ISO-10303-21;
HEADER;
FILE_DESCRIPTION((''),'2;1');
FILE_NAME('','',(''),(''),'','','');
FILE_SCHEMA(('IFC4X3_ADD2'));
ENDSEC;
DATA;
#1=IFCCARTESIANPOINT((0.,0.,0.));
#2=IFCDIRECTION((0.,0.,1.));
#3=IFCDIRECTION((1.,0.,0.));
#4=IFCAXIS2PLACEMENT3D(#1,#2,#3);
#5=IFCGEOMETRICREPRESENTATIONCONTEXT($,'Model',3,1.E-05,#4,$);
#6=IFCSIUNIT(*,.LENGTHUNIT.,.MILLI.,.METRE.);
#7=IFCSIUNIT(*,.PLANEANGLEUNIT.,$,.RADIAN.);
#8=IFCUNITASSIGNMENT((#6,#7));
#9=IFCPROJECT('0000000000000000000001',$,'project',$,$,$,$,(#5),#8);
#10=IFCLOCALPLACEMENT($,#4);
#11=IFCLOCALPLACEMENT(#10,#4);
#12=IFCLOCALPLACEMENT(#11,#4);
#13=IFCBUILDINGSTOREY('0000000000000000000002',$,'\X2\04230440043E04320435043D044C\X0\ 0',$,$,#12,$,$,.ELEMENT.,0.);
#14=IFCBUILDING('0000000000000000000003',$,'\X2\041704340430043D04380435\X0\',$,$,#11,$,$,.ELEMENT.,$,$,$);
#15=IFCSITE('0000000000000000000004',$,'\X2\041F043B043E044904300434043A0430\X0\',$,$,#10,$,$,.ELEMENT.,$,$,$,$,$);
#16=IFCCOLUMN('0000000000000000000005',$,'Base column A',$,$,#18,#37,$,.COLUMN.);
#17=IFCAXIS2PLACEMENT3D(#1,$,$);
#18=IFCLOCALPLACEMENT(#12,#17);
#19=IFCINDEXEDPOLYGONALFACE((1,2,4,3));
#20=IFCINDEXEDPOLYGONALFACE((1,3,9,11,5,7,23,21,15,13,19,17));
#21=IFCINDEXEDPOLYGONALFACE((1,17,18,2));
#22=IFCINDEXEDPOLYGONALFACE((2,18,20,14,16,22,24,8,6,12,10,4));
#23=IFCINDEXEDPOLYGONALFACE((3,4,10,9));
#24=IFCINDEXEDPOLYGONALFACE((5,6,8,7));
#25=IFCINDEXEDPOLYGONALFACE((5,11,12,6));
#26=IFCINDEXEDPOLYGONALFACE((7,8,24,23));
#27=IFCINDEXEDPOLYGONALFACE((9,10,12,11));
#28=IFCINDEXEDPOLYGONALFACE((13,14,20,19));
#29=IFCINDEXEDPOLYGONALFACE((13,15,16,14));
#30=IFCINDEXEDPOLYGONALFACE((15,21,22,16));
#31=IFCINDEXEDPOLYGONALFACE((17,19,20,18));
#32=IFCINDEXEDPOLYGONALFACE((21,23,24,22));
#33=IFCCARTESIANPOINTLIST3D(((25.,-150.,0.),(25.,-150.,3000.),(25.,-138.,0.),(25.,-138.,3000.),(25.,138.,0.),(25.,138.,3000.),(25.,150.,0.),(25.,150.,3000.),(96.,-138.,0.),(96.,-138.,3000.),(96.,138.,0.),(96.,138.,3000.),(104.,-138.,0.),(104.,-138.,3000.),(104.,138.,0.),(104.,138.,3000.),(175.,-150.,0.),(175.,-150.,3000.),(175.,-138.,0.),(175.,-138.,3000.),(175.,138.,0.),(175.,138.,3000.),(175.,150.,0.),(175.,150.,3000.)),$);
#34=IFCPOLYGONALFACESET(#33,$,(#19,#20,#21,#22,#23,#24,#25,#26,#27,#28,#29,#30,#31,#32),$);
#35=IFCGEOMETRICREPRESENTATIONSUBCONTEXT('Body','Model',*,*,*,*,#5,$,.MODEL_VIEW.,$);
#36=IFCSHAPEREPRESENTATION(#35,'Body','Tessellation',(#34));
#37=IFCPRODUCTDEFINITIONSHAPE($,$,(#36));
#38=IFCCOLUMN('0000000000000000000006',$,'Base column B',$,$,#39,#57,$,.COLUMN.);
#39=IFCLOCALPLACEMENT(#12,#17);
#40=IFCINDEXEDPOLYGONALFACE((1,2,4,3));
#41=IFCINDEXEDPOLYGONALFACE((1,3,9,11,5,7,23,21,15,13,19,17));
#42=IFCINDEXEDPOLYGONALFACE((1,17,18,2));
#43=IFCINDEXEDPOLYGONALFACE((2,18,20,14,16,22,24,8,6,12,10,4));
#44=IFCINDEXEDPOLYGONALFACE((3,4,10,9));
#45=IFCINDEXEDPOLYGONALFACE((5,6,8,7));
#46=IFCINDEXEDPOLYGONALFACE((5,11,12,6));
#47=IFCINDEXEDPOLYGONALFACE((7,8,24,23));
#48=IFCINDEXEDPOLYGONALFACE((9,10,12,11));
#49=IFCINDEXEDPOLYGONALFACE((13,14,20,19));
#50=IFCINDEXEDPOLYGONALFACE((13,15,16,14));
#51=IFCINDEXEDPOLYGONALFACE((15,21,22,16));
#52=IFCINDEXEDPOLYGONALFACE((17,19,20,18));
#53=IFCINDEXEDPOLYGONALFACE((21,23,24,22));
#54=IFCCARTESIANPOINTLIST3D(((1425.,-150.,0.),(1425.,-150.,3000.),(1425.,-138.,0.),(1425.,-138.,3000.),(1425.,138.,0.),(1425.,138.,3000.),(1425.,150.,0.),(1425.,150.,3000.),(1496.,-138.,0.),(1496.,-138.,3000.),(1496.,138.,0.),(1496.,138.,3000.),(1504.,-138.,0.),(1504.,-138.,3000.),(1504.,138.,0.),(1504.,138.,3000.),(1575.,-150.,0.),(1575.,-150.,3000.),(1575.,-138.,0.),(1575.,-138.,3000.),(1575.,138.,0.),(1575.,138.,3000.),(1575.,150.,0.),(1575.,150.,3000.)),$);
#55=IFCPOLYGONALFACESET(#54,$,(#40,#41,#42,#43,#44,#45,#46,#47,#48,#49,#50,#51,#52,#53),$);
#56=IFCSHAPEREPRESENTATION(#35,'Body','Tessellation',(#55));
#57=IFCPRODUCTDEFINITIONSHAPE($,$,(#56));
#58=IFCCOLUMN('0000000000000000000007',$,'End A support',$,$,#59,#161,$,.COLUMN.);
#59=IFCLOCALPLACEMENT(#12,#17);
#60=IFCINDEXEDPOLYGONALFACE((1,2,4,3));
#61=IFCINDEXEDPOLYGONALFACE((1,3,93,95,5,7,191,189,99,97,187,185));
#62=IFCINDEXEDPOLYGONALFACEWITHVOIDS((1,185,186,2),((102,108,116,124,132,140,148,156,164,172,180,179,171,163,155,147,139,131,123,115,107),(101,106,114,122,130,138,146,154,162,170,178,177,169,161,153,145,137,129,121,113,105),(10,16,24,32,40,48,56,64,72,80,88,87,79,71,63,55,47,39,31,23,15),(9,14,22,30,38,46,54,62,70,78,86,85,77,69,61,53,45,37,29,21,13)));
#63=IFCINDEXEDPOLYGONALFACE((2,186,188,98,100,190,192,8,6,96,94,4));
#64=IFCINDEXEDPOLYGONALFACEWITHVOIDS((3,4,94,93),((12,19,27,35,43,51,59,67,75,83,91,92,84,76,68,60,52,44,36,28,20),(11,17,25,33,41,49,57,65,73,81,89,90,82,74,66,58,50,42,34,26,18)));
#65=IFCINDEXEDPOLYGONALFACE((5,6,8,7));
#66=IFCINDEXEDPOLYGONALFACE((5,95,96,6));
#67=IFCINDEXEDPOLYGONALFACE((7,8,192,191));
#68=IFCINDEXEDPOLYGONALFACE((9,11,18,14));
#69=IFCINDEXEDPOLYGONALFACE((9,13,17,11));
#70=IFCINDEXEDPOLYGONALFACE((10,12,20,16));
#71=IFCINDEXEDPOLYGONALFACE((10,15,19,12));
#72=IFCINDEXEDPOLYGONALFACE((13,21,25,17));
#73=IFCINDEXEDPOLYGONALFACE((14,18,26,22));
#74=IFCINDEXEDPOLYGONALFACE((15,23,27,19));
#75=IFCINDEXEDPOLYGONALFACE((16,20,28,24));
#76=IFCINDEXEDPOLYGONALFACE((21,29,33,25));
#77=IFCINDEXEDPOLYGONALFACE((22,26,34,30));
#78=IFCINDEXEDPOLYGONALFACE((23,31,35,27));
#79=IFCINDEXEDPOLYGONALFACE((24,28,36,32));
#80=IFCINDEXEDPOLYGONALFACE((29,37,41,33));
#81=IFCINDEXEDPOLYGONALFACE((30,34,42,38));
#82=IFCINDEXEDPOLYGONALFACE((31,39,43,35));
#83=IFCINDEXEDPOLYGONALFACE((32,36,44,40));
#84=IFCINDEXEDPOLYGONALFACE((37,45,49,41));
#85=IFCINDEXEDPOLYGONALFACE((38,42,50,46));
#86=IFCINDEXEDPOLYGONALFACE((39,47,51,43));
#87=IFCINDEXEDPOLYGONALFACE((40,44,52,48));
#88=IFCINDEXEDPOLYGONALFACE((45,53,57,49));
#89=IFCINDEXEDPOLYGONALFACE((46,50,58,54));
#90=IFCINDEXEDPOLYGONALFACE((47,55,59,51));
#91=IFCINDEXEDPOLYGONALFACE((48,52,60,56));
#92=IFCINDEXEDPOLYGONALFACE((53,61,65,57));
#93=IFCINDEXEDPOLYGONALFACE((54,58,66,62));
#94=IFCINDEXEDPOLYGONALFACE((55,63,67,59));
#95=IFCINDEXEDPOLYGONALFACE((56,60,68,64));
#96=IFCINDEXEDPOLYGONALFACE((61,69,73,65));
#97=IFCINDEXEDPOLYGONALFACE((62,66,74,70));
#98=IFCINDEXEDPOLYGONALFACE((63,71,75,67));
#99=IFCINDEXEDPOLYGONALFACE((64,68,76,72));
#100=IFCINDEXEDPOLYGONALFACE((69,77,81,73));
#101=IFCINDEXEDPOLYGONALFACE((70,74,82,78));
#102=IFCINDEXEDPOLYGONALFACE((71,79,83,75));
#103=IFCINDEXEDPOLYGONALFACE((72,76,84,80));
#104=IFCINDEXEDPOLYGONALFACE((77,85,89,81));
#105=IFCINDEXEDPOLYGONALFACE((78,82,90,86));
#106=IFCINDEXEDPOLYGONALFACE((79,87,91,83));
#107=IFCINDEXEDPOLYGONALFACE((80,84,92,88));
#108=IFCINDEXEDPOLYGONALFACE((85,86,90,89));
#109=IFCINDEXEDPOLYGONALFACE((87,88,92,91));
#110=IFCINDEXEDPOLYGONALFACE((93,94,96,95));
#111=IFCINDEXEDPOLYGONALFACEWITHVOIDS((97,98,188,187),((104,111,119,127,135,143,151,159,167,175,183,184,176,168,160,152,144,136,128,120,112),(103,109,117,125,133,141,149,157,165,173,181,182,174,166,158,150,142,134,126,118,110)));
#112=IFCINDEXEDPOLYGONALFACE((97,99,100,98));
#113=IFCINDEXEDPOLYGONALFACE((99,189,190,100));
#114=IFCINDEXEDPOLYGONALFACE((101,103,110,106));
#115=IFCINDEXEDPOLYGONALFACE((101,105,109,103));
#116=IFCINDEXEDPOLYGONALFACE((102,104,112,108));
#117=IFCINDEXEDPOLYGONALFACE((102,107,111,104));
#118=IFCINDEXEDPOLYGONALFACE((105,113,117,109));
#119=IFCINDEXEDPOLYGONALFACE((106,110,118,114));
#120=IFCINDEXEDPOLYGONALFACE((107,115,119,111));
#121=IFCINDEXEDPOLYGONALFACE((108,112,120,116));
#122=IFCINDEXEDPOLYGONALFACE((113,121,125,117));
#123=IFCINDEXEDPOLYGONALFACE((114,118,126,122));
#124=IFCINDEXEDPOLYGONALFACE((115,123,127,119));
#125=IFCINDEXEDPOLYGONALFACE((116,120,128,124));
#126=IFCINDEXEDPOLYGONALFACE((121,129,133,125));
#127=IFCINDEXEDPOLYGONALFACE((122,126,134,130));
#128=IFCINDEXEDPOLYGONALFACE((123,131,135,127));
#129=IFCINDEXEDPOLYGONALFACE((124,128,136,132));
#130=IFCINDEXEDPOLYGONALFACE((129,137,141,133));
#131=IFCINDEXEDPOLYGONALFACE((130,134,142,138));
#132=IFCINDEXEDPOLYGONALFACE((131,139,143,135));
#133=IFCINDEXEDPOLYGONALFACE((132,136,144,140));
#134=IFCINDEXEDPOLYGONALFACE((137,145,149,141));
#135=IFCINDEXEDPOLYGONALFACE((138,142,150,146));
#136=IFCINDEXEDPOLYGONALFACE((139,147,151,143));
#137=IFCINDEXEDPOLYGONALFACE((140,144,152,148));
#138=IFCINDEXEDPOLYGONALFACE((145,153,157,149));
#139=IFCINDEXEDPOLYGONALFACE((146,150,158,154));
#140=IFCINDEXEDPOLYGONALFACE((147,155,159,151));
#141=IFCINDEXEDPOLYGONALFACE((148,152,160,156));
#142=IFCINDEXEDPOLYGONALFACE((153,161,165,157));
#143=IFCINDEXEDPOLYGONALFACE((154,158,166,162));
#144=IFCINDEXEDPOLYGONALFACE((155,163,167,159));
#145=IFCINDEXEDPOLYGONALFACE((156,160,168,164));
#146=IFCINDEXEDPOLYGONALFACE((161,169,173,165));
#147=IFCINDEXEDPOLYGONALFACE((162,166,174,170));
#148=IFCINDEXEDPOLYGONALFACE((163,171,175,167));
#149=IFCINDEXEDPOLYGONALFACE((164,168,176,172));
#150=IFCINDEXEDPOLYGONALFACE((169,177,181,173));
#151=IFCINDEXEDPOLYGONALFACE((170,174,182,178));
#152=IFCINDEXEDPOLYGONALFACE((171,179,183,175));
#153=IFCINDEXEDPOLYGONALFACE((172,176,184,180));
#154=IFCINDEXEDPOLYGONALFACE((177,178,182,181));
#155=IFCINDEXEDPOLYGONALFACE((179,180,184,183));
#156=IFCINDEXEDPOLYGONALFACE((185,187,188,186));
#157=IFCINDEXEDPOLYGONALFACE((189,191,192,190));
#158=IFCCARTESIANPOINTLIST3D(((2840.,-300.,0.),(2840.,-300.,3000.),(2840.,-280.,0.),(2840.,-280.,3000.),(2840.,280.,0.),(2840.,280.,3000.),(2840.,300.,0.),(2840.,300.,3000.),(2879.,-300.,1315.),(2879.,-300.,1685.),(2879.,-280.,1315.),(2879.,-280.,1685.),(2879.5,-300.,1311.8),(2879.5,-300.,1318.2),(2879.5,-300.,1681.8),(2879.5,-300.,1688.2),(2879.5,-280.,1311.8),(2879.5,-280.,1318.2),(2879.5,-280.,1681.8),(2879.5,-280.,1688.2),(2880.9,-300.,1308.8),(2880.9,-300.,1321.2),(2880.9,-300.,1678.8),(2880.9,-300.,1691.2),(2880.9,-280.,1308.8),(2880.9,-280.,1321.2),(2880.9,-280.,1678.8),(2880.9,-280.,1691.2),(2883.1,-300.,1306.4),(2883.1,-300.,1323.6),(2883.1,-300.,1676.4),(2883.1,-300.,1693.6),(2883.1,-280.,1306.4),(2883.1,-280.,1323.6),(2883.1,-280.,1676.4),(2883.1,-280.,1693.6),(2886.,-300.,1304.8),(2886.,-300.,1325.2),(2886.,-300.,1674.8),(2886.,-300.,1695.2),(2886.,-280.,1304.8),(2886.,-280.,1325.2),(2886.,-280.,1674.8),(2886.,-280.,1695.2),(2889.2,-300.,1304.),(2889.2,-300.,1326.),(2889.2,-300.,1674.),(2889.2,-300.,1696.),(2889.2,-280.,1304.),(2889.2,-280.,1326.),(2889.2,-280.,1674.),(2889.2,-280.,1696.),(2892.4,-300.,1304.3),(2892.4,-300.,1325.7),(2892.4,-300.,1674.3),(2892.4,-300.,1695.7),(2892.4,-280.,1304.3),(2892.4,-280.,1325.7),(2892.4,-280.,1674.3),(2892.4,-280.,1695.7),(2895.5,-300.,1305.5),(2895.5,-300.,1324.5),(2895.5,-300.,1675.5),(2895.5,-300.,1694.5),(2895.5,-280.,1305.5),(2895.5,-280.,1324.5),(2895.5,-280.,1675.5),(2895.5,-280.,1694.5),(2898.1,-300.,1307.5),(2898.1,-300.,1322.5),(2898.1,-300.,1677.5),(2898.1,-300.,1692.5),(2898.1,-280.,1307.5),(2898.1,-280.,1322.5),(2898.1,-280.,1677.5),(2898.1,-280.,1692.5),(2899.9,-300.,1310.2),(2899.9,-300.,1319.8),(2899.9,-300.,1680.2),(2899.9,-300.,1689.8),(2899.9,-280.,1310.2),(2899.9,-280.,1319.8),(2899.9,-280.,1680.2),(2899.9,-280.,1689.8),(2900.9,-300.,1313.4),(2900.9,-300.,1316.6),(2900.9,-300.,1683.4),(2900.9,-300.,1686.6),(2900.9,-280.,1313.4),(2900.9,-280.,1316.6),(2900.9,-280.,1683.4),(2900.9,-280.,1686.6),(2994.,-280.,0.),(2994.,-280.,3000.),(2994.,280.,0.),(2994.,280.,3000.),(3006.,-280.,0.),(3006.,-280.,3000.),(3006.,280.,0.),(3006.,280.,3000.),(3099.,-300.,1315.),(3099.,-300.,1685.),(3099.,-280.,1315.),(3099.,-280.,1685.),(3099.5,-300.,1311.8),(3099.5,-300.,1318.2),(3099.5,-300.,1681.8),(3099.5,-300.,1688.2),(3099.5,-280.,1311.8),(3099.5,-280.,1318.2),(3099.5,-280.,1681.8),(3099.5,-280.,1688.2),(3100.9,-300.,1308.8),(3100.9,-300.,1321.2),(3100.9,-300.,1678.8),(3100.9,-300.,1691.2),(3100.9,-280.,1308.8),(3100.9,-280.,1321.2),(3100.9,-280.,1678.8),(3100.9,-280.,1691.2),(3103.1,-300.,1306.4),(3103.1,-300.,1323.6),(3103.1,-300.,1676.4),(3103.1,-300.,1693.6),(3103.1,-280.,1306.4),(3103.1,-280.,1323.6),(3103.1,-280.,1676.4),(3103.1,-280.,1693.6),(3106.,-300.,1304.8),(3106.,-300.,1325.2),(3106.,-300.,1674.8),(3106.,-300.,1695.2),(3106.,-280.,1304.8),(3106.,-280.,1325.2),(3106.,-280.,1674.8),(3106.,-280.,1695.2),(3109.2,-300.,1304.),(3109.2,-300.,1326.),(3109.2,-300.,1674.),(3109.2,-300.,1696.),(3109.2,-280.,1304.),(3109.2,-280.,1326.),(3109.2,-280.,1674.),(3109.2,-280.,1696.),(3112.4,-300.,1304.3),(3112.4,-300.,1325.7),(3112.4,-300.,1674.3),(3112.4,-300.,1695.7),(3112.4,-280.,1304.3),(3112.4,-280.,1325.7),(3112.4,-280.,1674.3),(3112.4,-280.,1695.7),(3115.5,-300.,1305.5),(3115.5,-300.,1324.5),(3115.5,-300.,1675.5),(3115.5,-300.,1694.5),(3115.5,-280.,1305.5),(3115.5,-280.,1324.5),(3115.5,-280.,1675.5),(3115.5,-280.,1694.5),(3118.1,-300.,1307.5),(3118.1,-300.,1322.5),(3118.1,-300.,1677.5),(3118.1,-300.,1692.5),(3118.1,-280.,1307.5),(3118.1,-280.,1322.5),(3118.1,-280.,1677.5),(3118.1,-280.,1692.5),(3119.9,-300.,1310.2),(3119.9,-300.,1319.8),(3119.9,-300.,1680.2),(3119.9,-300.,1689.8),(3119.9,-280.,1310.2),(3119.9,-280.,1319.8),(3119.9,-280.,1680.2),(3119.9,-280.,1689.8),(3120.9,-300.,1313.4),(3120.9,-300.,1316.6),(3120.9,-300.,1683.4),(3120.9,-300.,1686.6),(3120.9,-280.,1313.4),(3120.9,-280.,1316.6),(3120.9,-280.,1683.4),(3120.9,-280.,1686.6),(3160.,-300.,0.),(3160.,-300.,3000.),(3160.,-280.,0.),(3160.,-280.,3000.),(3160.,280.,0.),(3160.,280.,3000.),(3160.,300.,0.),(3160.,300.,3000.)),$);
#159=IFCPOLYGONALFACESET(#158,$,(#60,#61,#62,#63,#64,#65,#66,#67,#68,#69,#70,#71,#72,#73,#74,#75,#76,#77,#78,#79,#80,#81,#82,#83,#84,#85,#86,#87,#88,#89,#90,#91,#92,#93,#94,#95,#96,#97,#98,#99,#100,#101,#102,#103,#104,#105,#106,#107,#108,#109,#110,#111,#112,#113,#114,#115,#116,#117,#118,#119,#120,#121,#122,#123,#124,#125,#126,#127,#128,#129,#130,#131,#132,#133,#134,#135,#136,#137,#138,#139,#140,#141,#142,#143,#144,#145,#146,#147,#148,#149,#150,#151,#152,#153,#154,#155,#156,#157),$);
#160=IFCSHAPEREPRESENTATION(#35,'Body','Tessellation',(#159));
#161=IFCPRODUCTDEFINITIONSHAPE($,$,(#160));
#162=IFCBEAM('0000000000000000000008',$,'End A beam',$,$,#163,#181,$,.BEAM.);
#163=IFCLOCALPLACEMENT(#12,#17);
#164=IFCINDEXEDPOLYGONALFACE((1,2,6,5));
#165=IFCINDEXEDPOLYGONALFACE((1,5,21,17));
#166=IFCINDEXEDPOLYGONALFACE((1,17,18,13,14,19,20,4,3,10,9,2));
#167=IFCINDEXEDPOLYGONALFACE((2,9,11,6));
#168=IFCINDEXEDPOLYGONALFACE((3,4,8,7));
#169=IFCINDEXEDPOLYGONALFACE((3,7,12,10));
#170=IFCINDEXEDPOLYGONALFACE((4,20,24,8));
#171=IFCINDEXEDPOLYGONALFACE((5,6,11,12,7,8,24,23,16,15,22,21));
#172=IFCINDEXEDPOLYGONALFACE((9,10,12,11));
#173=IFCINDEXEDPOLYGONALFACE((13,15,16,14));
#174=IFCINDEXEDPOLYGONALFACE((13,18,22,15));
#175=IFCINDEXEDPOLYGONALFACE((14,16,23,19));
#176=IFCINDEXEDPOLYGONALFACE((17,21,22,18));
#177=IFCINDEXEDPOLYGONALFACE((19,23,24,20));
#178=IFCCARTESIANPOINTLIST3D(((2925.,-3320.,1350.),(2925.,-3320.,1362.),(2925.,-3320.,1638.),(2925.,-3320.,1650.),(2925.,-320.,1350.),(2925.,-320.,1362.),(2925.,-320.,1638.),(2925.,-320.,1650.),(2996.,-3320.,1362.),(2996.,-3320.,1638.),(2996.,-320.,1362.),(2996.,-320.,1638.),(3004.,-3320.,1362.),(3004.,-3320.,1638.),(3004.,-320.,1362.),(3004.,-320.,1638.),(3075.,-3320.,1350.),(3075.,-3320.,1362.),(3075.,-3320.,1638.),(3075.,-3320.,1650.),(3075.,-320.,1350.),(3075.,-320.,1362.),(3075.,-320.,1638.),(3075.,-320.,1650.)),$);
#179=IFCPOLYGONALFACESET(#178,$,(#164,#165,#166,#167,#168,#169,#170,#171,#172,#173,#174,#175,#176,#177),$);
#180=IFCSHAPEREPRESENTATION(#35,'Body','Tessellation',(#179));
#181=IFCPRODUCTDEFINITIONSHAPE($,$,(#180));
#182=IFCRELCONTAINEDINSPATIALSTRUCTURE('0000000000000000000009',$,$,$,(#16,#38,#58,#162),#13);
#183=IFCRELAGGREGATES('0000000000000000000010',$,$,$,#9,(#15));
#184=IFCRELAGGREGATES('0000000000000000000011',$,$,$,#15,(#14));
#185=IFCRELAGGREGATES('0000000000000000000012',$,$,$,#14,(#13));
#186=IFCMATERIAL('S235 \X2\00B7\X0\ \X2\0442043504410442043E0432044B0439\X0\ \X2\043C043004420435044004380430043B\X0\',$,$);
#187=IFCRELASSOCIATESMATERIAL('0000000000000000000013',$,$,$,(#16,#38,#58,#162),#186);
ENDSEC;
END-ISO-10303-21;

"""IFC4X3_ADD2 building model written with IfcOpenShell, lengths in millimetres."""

from ifc_helpers import new_model, si_unit, frame, origin_with_axes, place, context, subcontext, project, spatial, circle, i_section, extrude, material, element, save


model = new_model("IFC4X3_ADD2")

# Units and contexts
model_context = context("Model", 3, precision=1e-05, world=origin_with_axes())
body_context = subcontext(model_context, "Body", "Model", "MODEL_VIEW")
ifc_project = project(units=[si_unit("LENGTHUNIT", "METRE", prefix="MILLI"), si_unit("PLANEANGLEUNIT", "RADIAN")], contexts=[model_context])

# Site, building, storey
site_placement = place(None, origin_with_axes())
site = spatial("IfcSite", under=ifc_project, at=site_placement, Name="Площадка", CompositionType="ELEMENT")
building_placement = place(site_placement, origin_with_axes())
building = spatial("IfcBuilding", under=site, at=building_placement, Name="Здание", CompositionType="ELEMENT")
storey_placement = place(building_placement, origin_with_axes())
storey = spatial("IfcBuildingStorey", under=building, at=storey_placement, Name="Уровень 0", CompositionType="ELEMENT", Elevation=0.0)

# Columns
ifc_material = material(Name="S235 · тестовый материал")
for number, where, z_axis, x_axis, name in (
    (1, (100.0, 0.0, 0.0), (0.0, 0.0, 1.0), (1.0, 0.0, 0.0), "Base column A"),
    (2, (1500.0, 0.0, 0.0), (0.0, 0.0, 1.0), (1.0, 0.0, 0.0), "Base column B"),
):
    element("IfcColumn", number, at=place(storey_placement, frame(where, z_axis=z_axis, x_axis=x_axis)), inside=storey, material=ifc_material, Name=name, PredefinedType="COLUMN", context=body_context, shape_type="SweptSolid", body=[
        extrude(i_section(OverallWidth=150.0, OverallDepth=300.0, WebThickness=8.0, FlangeThickness=12.0), origin_with_axes(), (0.0, 0.0, 1.0), 3000.0),
    ])

# Column, openings
column_placement = place(storey_placement, frame((3000.0, 0.0, 0.0), z_axis=(0.0, 0.0, 1.0), x_axis=(1.0, 0.0, 0.0)))
column = element("IfcColumn", 3, at=column_placement, inside=storey, material=ifc_material, Name="End A support", PredefinedType="COLUMN", context=body_context, shape_type="SweptSolid", body=[
    extrude(i_section(OverallWidth=320.0, OverallDepth=600.0, WebThickness=12.0, FlangeThickness=20.0), origin_with_axes(), (0.0, 0.0, 1.0), 3000.0),
])
opening_1_placement = place(column_placement, frame((110.0, -321.0, 1315.0), z_axis=(0.0, 1.0, 0.0), x_axis=(-1.0, 0.0, 0.0)))
element("IfcOpeningElement", 4, at=opening_1_placement, cuts=column, PredefinedType="OPENING", context=body_context, shape_type="SweptSolid", body=[
    extrude(circle(Radius=11.0), origin_with_axes(), (0.0, 0.0, 1.0), 42.0),
])
opening_2_placement = place(column_placement, frame((110.0, -321.0, 1685.0), z_axis=(0.0, 1.0, 0.0), x_axis=(-1.0, 0.0, 0.0)))
element("IfcOpeningElement", 5, at=opening_2_placement, cuts=column, PredefinedType="OPENING", context=body_context, shape_type="SweptSolid", body=[
    extrude(circle(Radius=11.0), origin_with_axes(), (0.0, 0.0, 1.0), 42.0),
])
opening_3_placement = place(column_placement, frame((-110.0, -321.0, 1315.0), z_axis=(0.0, 1.0, 0.0), x_axis=(-1.0, 0.0, 0.0)))
element("IfcOpeningElement", 6, at=opening_3_placement, cuts=column, PredefinedType="OPENING", context=body_context, shape_type="SweptSolid", body=[
    extrude(circle(Radius=11.0), origin_with_axes(), (0.0, 0.0, 1.0), 42.0),
])
opening_4_placement = place(column_placement, frame((-110.0, -321.0, 1685.0), z_axis=(0.0, 1.0, 0.0), x_axis=(-1.0, 0.0, 0.0)))
element("IfcOpeningElement", 7, at=opening_4_placement, cuts=column, PredefinedType="OPENING", context=body_context, shape_type="SweptSolid", body=[
    extrude(circle(Radius=11.0), origin_with_axes(), (0.0, 0.0, 1.0), 42.0),
])

# Beam
beam_1_placement = place(storey_placement, frame((3000.0, -3320.0, 1500.0), z_axis=(0.0, 1.0, 0.0), x_axis=(-1.0, 0.0, 0.0)))
element("IfcBeam", 8, at=beam_1_placement, inside=storey, material=ifc_material, Name="End A beam", PredefinedType="BEAM", context=body_context, shape_type="SweptSolid", body=[
    extrude(i_section(OverallWidth=150.0, OverallDepth=300.0, WebThickness=8.0, FlangeThickness=12.0), origin_with_axes(), (0.0, 0.0, 1.0), 3000.0),
])

save(model, "model.ifc")
